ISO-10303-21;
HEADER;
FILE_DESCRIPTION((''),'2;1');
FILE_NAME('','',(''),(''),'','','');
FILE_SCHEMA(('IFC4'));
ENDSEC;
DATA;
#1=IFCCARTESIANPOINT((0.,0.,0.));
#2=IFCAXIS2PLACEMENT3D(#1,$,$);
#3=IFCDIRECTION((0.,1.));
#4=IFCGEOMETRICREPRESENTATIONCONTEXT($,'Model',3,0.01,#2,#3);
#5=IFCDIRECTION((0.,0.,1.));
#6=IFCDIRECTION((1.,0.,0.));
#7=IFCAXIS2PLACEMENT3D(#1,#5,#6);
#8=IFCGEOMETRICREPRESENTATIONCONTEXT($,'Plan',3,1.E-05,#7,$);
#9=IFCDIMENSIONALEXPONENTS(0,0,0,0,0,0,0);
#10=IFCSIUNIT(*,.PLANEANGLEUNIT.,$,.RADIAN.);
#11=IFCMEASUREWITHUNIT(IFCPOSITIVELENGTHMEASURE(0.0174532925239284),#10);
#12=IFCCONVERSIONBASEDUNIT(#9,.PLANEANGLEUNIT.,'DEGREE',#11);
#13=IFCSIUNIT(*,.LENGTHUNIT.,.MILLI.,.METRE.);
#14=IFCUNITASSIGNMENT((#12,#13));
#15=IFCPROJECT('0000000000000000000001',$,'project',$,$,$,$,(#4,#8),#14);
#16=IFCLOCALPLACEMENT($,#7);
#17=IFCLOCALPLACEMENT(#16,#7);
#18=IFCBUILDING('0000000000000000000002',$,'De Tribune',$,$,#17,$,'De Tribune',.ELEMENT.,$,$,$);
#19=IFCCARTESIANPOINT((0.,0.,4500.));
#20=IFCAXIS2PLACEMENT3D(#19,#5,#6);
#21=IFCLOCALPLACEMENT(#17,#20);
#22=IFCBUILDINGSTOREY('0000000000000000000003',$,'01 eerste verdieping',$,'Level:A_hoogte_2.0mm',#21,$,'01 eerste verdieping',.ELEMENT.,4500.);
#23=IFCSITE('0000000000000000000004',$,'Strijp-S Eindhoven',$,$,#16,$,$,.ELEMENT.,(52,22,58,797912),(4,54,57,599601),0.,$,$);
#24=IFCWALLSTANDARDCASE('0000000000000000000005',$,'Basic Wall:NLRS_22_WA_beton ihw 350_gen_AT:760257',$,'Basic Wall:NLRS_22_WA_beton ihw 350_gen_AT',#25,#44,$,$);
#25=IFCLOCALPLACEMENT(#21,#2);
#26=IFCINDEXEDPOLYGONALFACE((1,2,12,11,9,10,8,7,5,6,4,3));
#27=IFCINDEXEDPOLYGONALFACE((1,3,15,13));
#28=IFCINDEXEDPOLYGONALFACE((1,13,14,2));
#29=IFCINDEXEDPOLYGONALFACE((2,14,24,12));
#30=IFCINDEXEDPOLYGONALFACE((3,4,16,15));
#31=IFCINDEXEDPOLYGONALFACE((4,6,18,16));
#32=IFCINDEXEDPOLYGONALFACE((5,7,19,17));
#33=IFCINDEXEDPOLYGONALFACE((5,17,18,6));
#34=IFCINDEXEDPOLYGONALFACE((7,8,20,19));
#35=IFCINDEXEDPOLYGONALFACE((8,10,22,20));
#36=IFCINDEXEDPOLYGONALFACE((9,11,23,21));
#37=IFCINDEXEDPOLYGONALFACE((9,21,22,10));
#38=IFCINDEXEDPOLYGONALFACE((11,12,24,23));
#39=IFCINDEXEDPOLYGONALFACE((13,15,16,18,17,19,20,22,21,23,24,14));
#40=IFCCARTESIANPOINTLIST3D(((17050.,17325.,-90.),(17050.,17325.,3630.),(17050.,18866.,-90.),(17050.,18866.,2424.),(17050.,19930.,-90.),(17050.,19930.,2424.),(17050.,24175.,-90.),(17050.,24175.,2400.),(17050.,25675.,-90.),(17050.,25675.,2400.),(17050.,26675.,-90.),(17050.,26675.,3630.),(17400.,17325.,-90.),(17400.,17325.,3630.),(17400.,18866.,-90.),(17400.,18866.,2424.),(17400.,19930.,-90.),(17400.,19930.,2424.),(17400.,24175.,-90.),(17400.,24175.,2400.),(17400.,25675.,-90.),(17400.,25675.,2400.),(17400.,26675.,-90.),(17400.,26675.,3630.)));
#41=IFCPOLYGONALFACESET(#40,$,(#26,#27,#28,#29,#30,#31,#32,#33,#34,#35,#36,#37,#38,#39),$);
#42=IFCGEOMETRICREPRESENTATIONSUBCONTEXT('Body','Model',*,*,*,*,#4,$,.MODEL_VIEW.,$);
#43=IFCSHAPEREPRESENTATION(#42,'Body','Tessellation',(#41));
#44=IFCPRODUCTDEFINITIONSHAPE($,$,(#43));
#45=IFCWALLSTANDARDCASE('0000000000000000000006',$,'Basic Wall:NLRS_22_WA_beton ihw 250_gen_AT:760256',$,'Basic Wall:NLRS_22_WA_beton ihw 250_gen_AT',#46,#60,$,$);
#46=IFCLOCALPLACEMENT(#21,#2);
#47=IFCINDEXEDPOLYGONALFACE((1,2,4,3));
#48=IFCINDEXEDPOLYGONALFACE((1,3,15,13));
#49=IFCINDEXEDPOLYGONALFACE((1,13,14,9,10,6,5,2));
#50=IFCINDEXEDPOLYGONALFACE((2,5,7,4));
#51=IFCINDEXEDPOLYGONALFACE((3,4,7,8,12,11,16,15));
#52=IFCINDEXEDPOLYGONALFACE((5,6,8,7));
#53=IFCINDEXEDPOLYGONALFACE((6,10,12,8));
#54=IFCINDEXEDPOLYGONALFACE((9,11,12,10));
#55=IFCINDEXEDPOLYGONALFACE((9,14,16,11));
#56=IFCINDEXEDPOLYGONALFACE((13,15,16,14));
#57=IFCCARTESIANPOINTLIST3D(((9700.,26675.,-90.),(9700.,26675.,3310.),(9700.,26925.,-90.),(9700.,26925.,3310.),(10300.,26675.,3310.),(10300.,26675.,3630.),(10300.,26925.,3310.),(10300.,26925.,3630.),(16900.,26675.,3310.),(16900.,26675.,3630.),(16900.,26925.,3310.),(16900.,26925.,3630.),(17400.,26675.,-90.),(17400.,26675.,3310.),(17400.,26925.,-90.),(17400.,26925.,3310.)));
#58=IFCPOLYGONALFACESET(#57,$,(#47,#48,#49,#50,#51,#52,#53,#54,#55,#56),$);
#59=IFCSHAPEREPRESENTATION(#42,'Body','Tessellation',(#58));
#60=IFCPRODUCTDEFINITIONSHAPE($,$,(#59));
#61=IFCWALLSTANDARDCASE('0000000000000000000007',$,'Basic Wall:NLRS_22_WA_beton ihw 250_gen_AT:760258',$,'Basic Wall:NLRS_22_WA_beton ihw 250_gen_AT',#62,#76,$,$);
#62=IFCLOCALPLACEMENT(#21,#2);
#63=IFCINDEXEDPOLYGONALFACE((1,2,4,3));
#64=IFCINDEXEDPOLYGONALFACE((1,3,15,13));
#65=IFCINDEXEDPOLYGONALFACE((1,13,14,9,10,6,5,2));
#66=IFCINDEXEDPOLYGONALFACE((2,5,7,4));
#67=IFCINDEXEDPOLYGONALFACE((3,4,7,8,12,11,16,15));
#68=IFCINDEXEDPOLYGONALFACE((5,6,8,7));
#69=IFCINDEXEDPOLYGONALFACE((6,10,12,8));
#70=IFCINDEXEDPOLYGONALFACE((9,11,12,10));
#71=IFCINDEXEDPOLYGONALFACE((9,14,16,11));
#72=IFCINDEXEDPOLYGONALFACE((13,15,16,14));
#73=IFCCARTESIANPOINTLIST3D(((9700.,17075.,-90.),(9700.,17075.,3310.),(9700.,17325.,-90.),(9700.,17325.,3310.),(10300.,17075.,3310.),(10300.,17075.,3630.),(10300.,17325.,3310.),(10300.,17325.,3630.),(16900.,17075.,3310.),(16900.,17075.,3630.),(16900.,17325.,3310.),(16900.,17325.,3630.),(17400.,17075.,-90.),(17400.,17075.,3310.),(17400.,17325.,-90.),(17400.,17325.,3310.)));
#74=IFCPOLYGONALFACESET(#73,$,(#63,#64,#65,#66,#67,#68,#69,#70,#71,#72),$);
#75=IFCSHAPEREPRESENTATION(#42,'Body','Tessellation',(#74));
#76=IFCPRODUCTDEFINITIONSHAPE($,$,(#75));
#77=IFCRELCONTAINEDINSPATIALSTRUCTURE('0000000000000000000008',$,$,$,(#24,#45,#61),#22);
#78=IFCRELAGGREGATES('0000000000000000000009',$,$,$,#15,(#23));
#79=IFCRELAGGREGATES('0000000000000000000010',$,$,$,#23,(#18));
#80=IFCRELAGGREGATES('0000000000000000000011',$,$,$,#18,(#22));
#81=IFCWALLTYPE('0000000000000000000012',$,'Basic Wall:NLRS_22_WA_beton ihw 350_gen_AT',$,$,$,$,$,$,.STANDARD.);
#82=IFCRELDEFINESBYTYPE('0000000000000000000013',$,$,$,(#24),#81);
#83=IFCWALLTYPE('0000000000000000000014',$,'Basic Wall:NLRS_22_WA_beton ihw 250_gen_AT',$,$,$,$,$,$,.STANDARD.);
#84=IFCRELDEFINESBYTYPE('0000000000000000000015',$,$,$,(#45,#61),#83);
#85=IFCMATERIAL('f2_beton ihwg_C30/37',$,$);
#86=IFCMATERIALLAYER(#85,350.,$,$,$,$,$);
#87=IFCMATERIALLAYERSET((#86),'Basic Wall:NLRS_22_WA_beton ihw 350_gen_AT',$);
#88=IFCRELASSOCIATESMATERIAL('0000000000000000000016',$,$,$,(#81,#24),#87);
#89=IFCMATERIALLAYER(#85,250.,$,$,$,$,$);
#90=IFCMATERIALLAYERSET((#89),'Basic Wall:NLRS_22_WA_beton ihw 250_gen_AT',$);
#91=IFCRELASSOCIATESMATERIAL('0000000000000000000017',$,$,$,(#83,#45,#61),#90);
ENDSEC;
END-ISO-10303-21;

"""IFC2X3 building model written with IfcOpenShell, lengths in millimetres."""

from ifc_helpers import new_model, entity, si_unit, converted_unit, direction, frame, frame_2d, origin, origin_with_axes, place, context, subcontext, project, spatial, rectangle, extrude, material, layer, layer_set, layer_usage, type_object, element, save


model = new_model("IFC2X3")

# Units and contexts
model_context = context("Model", 3, precision=0.01, world=origin(), true_north=direction((0.0, 1.0)))
plan_context = context("Plan", 3, precision=1e-05, world=origin_with_axes())
body_context = subcontext(model_context, "Body", "Model", "MODEL_VIEW")
ifc_project = project(units=[converted_unit("PLANEANGLEUNIT", "DEGREE", entity("IfcPositiveLengthMeasure", 0.0174532925239284), si_unit("PLANEANGLEUNIT", "RADIAN"), dimensions=[0, 0, 0, 0, 0, 0, 0]), si_unit("LENGTHUNIT", "METRE", prefix="MILLI")], contexts=[model_context, plan_context])

# Site, building, storey
site_placement = place(None, origin_with_axes())
site = spatial("IfcSite", under=ifc_project, at=site_placement, Name="Strijp-S Eindhoven", CompositionType="ELEMENT", RefLatitude=(52, 22, 58, 797912), RefLongitude=(4, 54, 57, 599601), RefElevation=0.0)
building_placement = place(site_placement, origin_with_axes())
building = spatial("IfcBuilding", under=site, at=building_placement, Name="De Tribune", LongName="De Tribune", CompositionType="ELEMENT")
storey_placement = place(building_placement, frame((0.0, 0.0, 4500.0), z_axis=(0.0, 0.0, 1.0), x_axis=(1.0, 0.0, 0.0)))
storey = spatial("IfcBuildingStorey", under=building, at=storey_placement, Name="01 eerste verdieping", ObjectType="Level:A_hoogte_2.0mm", LongName="01 eerste verdieping", CompositionType="ELEMENT", Elevation=4500.0)

# Shared definitions
ifc_material = material(Name="f2_beton ihwg_C30/37")

# Walls, openings
ifc_layer_1 = layer(ifc_material, 350.0)
ifc_layer_set_1 = layer_set([ifc_layer_1], Name="Basic Wall:NLRS_22_WA_beton ihw 350_gen_AT")
ifc_layer_usage_1 = layer_usage(ifc_layer_set_1, "AXIS2", "NEGATIVE", 175.0)
wall_type_1 = type_object("IfcWallType", Name="Basic Wall:NLRS_22_WA_beton ihw 350_gen_AT", PredefinedType="STANDARD", material=ifc_layer_set_1)
wall_1_placement = place(storey_placement, frame((17225.0, 26675.0, -90.0), z_axis=(0.0, 0.0, 1.0), x_axis=(0.0, -1.0, 0.0)))
wall_1 = element("IfcWallStandardCase", 1, at=wall_1_placement, inside=storey, type_object=wall_type_1, material=ifc_layer_usage_1, Name="Basic Wall:NLRS_22_WA_beton ihw 350_gen_AT:760257", ObjectType="Basic Wall:NLRS_22_WA_beton ihw 350_gen_AT", context=body_context, shape_type="SweptSolid", body=[
    extrude(rectangle(XDim=9350.0, YDim=350.0, at=frame_2d((4675.0, 0.0), x_axis=(1.0, 0.0))), origin(), (0.0, 0.0, 1.0), 3720.0),
])
opening_1_placement = place(wall_1_placement, frame((26675.0, -17225.0, 90.0), z_axis=(0.0, 0.0, 1.0), x_axis=(0.0, 1.0, 0.0)))
element("IfcOpeningElement", 2, at=opening_1_placement, cuts=wall_1, ObjectType="Opening", context=body_context, shape_type="SweptSolid", body=[
    extrude(rectangle(XDim=2514.0, YDim=1064.0, at=frame_2d((0.0, 0.0), x_axis=(0.0, 1.0))), frame((15526.0, 19398.0, 1167.0), z_axis=(1.0, 0.0, 0.0), x_axis=(0.0, -1.0, 0.0)), (0.0, 0.0, 1.0), 3048.0),
])
opening_2_placement = place(wall_1_placement, frame((26675.0, -17225.0, 90.0), z_axis=(0.0, 0.0, 1.0), x_axis=(0.0, 1.0, 0.0)))
element("IfcOpeningElement", 3, at=opening_2_placement, cuts=wall_1, ObjectType="Opening", context=body_context, shape_type="SweptSolid", body=[
    extrude(rectangle(XDim=2490.0, YDim=1500.0, at=frame_2d((0.0, 0.0), x_axis=(0.0, 1.0))), frame((15526.0, 24925.0, 1155.0), z_axis=(1.0, 0.0, 0.0), x_axis=(0.0, -1.0, 0.0)), (0.0, 0.0, 1.0), 3048.0),
])
ifc_layer_2 = layer(ifc_material, 250.0)
ifc_layer_set_2 = layer_set([ifc_layer_2], Name="Basic Wall:NLRS_22_WA_beton ihw 250_gen_AT")
ifc_layer_usage_2 = layer_usage(ifc_layer_set_2, "AXIS2", "NEGATIVE", 125.0)
wall_type_2 = type_object("IfcWallType", Name="Basic Wall:NLRS_22_WA_beton ihw 250_gen_AT", PredefinedType="STANDARD", material=ifc_layer_set_2)
wall_2_placement = place(storey_placement, frame((9700.0, 26800.0, -90.0), z_axis=(0.0, 0.0, 1.0), x_axis=(1.0, 0.0, 0.0)))
wall_2 = element("IfcWallStandardCase", 4, at=wall_2_placement, inside=storey, type_object=wall_type_2, material=ifc_layer_usage_2, Name="Basic Wall:NLRS_22_WA_beton ihw 250_gen_AT:760256", ObjectType="Basic Wall:NLRS_22_WA_beton ihw 250_gen_AT", context=body_context, shape_type="SweptSolid", body=[
    extrude(rectangle(XDim=7700.0, YDim=250.0, at=frame_2d((3850.0, 0.0), x_axis=(-1.0, 0.0))), origin(), (0.0, 0.0, 1.0), 3720.0),
])
opening_3_placement = place(wall_2_placement, origin_with_axes())
element("IfcOpeningElement", 5, at=opening_3_placement, cuts=wall_2, ObjectType="Opening", context=body_context, shape_type="SweptSolid", body=[
    extrude(rectangle(XDim=320.0, YDim=500.0, at=frame_2d((0.0, 0.0), x_axis=(1.0, 0.0))), frame((7450.0, 125.0, 3560.0), z_axis=(0.0, -1.0, 0.0), x_axis=(0.0, 0.0, 1.0)), (0.0, 0.0, 1.0), 250.0),
])
opening_4_placement = place(wall_2_placement, origin_with_axes())
element("IfcOpeningElement", 6, at=opening_4_placement, cuts=wall_2, ObjectType="Opening", context=body_context, shape_type="SweptSolid", body=[
    extrude(rectangle(XDim=320.0, YDim=600.0, at=frame_2d((0.0, 0.0), x_axis=(0.0, 1.0))), frame((300.0, 125.0, 3560.0), z_axis=(0.0, -1.0, 0.0), x_axis=(-1.0, 0.0, 0.0)), (0.0, 0.0, 1.0), 250.0),
])
ifc_layer_usage_3 = layer_usage(ifc_layer_set_2, "AXIS2", "NEGATIVE", 125.0)
wall_3_placement = place(storey_placement, frame((17400.0, 17200.0, -90.0), z_axis=(0.0, 0.0, 1.0), x_axis=(-1.0, 0.0, 0.0)))
wall_3 = element("IfcWallStandardCase", 7, at=wall_3_placement, inside=storey, type_object=wall_type_2, material=ifc_layer_usage_3, Name="Basic Wall:NLRS_22_WA_beton ihw 250_gen_AT:760258", ObjectType="Basic Wall:NLRS_22_WA_beton ihw 250_gen_AT", context=body_context, shape_type="SweptSolid", body=[
    extrude(rectangle(XDim=7700.0, YDim=250.0, at=frame_2d((3850.0, 0.0), x_axis=(-1.0, 0.0))), origin(), (0.0, 0.0, 1.0), 3720.0),
])
opening_5_placement = place(wall_3_placement, origin_with_axes())
element("IfcOpeningElement", 8, at=opening_5_placement, cuts=wall_3, ObjectType="Opening", context=body_context, shape_type="SweptSolid", body=[
    extrude(rectangle(XDim=320.0, YDim=600.0, at=frame_2d((0.0, 0.0), x_axis=(1.0, 0.0))), frame((7400.0, 125.0, 3560.0), z_axis=(0.0, -1.0, 0.0), x_axis=(0.0, 0.0, 1.0)), (0.0, 0.0, 1.0), 250.0),
])
opening_6_placement = place(wall_3_placement, origin_with_axes())
element("IfcOpeningElement", 9, at=opening_6_placement, cuts=wall_3, ObjectType="Opening", context=body_context, shape_type="SweptSolid", body=[
    extrude(rectangle(XDim=320.0, YDim=500.0, at=frame_2d((0.0, 0.0), x_axis=(0.0, 1.0))), frame((250.0, 125.0, 3560.0), z_axis=(0.0, -1.0, 0.0), x_axis=(-1.0, 0.0, 0.0)), (0.0, 0.0, 1.0), 250.0),
])

save(model, "model.ifc")
